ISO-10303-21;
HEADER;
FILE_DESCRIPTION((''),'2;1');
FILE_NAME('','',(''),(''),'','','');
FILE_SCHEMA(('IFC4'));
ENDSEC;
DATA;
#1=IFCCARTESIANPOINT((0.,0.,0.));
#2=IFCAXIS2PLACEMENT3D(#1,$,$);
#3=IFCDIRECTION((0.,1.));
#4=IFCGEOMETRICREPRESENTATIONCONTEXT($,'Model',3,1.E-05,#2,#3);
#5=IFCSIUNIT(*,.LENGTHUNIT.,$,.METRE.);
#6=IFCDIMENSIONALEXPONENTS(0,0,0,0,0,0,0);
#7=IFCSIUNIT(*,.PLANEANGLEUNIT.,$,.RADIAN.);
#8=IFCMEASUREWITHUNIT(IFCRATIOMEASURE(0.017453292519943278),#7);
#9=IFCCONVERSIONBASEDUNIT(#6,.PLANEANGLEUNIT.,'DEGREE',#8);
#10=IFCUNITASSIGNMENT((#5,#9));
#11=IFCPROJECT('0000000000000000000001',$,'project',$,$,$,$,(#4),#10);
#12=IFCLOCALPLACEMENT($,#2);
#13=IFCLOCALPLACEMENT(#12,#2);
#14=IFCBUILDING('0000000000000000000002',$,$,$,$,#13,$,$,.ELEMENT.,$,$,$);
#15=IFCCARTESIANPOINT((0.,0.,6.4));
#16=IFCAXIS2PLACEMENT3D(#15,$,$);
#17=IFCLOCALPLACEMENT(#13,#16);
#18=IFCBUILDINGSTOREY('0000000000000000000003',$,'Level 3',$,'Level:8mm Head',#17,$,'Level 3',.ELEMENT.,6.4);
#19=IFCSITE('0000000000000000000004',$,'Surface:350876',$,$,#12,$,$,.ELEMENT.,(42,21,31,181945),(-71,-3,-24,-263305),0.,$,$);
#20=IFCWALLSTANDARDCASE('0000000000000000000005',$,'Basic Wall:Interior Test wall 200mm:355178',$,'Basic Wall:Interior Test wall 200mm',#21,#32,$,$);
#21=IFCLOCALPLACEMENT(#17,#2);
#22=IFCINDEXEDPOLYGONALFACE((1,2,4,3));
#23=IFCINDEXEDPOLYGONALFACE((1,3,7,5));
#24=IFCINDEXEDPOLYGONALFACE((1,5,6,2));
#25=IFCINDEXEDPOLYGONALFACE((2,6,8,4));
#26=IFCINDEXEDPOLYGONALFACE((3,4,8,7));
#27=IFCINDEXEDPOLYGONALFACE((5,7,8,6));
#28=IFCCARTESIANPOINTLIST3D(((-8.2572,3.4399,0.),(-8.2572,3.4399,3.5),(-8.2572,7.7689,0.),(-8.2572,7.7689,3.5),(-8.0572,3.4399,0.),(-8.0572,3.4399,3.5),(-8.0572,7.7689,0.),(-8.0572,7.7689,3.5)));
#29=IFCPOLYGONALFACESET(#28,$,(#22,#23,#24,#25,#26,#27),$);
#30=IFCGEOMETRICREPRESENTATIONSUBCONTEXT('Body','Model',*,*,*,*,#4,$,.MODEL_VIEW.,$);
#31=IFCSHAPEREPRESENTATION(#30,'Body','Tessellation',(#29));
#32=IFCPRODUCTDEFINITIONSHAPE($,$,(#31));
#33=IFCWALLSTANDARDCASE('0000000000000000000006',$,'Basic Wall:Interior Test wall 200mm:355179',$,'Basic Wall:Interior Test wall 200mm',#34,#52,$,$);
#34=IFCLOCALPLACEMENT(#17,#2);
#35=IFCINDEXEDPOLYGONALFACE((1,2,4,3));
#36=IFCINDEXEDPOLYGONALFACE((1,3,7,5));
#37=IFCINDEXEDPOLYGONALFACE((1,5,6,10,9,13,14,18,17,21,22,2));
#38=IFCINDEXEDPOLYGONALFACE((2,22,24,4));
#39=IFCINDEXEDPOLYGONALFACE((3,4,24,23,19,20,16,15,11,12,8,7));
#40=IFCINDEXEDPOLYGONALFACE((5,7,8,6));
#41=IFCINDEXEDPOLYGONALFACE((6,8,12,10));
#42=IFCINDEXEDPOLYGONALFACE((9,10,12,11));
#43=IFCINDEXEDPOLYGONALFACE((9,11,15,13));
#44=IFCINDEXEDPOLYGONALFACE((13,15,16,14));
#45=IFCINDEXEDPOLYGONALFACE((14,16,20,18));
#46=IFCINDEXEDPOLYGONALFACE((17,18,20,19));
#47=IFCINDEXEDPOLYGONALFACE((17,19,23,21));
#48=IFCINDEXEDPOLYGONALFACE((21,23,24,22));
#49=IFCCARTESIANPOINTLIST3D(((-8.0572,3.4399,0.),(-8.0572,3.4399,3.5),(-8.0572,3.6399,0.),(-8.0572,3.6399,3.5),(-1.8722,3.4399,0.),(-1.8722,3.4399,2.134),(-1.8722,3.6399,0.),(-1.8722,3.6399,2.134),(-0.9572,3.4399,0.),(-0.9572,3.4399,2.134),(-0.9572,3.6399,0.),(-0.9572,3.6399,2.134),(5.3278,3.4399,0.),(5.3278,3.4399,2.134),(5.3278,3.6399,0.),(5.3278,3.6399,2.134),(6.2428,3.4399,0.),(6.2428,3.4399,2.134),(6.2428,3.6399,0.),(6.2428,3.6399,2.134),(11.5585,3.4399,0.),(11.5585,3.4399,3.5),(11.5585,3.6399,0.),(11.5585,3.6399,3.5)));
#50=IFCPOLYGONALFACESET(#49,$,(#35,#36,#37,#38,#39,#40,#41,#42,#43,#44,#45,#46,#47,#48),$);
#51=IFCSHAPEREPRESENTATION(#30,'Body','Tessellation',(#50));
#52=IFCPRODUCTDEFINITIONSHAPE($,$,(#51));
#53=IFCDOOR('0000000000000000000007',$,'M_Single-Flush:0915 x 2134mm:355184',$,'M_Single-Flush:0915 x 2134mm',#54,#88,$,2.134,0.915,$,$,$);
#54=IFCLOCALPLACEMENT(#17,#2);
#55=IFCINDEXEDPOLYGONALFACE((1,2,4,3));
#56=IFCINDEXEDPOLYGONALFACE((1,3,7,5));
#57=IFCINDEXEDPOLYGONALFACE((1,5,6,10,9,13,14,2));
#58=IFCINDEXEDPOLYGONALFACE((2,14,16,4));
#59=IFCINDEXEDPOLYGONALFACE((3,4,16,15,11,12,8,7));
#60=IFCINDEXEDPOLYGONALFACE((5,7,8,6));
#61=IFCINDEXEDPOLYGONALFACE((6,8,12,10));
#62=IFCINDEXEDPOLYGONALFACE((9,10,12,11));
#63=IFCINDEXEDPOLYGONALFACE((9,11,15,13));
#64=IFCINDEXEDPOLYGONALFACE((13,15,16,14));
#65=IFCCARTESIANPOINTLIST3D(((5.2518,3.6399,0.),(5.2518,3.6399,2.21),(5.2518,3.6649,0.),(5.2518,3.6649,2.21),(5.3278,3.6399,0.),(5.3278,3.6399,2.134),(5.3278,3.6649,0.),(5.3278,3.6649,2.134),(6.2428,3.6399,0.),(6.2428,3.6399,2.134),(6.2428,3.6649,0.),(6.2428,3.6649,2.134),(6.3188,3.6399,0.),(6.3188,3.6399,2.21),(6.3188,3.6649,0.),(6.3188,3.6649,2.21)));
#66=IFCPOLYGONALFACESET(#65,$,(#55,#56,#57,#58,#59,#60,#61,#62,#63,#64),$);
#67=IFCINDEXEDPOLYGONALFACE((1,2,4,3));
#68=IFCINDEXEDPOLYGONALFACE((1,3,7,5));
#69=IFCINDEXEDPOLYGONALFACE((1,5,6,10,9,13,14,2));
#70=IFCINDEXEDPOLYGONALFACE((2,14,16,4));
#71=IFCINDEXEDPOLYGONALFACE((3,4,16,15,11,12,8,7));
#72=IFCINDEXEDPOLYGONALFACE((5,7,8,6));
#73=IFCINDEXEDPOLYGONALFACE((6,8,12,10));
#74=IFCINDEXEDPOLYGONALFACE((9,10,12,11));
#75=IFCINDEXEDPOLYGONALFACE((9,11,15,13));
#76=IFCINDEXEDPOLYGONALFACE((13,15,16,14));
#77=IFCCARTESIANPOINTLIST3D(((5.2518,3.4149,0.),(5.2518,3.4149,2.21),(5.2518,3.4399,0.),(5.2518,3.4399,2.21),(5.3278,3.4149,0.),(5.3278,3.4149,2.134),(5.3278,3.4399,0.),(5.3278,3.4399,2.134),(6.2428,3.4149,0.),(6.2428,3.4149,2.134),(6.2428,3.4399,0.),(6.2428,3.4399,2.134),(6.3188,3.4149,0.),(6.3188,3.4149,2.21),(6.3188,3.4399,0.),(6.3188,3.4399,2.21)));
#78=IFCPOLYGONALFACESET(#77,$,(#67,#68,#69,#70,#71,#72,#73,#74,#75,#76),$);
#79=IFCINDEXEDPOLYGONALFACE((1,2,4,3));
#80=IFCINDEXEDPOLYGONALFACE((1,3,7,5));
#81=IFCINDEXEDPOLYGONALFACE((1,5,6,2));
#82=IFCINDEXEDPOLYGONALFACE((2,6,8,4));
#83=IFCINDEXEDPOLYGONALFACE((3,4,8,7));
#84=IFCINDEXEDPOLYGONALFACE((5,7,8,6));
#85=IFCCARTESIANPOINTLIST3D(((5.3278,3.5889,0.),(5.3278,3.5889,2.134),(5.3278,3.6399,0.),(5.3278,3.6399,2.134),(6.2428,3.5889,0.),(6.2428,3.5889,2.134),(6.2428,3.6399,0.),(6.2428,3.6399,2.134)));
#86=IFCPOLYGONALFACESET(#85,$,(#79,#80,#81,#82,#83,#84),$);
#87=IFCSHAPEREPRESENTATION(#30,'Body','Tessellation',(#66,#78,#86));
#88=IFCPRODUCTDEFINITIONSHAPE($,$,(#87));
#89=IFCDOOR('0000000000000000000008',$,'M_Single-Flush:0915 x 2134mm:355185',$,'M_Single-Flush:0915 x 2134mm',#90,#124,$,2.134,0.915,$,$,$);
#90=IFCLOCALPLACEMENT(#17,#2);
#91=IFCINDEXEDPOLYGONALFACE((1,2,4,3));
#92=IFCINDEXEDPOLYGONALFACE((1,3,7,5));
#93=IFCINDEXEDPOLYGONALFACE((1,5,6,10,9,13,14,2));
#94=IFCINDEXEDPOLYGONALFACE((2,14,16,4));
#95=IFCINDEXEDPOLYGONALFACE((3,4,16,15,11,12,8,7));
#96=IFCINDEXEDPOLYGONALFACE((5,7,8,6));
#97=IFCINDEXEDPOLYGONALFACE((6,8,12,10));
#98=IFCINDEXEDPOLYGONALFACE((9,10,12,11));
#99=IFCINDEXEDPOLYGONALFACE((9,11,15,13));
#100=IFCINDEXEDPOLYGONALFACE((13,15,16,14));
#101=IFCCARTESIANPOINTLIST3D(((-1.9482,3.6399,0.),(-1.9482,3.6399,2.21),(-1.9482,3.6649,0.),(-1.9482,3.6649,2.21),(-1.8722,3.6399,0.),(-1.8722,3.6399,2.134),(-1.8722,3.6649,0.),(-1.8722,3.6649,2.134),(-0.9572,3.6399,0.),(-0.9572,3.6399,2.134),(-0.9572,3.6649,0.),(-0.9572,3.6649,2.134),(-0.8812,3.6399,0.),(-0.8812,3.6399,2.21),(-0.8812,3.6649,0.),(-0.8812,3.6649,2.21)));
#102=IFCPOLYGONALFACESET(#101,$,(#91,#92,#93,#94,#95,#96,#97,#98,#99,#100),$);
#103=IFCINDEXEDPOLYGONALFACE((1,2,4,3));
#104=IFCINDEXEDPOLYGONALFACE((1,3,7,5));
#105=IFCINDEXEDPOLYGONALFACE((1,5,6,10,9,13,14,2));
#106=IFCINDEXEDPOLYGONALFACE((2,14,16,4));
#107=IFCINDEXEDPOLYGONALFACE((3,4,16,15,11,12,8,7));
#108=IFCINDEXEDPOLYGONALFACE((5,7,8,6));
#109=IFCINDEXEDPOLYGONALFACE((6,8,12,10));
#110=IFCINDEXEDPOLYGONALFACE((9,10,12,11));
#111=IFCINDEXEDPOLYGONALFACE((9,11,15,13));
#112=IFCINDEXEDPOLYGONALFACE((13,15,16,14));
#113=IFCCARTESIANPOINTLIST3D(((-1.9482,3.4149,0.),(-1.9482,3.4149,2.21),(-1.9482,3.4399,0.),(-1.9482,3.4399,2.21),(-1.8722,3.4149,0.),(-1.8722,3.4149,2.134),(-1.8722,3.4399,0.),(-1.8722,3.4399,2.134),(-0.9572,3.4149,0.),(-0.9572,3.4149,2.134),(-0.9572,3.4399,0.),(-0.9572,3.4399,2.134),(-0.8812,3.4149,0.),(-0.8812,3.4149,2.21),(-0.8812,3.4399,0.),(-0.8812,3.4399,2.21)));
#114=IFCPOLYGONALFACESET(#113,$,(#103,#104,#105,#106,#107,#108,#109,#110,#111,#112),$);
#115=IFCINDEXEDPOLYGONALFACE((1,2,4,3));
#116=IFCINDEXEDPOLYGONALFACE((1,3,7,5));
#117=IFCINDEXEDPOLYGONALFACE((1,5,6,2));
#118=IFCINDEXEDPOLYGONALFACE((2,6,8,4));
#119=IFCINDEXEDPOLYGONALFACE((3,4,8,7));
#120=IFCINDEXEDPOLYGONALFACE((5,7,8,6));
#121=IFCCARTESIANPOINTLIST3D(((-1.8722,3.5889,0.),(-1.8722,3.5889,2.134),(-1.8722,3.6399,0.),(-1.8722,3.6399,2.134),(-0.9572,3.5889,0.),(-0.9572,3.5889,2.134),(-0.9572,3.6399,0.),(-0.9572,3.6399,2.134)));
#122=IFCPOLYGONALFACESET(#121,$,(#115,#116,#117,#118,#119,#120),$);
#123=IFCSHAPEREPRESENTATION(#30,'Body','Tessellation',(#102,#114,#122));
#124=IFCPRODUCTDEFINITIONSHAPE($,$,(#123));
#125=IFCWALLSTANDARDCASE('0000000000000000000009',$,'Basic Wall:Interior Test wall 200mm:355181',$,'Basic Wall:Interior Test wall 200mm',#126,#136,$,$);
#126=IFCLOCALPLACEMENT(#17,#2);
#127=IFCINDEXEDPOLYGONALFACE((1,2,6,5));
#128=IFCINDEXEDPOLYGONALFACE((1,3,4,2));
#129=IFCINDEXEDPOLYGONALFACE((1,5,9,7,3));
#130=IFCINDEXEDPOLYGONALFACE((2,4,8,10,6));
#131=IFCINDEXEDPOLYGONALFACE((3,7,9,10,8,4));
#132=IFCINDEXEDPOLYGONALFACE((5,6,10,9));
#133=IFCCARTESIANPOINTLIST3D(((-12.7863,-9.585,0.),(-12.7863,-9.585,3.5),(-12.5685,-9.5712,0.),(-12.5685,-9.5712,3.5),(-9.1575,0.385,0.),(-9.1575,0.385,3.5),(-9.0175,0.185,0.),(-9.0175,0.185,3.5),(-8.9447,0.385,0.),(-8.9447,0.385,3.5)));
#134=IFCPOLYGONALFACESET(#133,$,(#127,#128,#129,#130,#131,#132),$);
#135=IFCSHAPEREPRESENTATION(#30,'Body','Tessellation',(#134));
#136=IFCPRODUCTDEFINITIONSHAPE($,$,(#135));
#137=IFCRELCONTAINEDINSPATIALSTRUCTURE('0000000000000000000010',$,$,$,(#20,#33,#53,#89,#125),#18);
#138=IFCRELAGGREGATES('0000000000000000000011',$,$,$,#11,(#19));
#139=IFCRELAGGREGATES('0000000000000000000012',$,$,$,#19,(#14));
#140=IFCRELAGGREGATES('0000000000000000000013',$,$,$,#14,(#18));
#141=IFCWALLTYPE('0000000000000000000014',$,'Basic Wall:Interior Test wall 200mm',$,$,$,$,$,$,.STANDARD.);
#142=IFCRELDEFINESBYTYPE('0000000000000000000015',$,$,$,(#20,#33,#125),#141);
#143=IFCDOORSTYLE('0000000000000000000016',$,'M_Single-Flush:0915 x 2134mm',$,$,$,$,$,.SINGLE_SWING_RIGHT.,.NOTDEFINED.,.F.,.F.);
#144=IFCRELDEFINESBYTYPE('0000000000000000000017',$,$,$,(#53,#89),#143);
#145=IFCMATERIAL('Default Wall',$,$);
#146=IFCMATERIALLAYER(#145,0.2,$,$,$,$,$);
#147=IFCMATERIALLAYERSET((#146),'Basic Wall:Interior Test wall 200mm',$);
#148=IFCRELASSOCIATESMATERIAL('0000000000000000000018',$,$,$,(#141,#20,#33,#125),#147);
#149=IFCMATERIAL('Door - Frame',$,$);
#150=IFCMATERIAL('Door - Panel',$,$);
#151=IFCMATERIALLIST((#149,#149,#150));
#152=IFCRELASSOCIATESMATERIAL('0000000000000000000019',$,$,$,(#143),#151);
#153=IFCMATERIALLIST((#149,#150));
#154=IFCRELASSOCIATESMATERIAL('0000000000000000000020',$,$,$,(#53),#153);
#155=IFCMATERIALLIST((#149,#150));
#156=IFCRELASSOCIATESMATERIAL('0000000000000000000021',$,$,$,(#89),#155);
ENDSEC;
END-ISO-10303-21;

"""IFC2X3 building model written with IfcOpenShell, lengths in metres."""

from ifc_helpers import new_model, entity, si_unit, converted_unit, direction, frame, frame_2d, origin, place, context, subcontext, project, spatial, polyline, rectangle, outline, extrude, source, transform, mapped, material, material_list, layer, layer_set, layer_usage, type_object, type_shapes, element, fill, save


model = new_model("IFC2X3")

# Units and contexts
model_context = context("Model", 3, precision=1e-05, world=origin(), true_north=direction((0.0, 1.0)))
body_context = subcontext(model_context, "Body", "Model", "MODEL_VIEW")
ifc_project = project(units=[si_unit("LENGTHUNIT", "METRE"), converted_unit("PLANEANGLEUNIT", "DEGREE", entity("IfcRatioMeasure", 0.017453292519943278), si_unit("PLANEANGLEUNIT", "RADIAN"), dimensions=[0, 0, 0, 0, 0, 0, 0])], contexts=[model_context])

# Site, building, storey
site_placement = place(None, origin())
site = spatial("IfcSite", under=ifc_project, at=site_placement, Name="Surface:350876", CompositionType="ELEMENT", RefLatitude=(42, 21, 31, 181945), RefLongitude=(-71, -3, -24, -263305), RefElevation=0.0)
building_placement = place(site_placement, origin())
building = spatial("IfcBuilding", under=site, at=building_placement, CompositionType="ELEMENT")
storey_placement = place(building_placement, frame((0.0, 0.0, 6.4)))
storey = spatial("IfcBuildingStorey", under=building, at=storey_placement, Name="Level 3", ObjectType="Level:8mm Head", LongName="Level 3", CompositionType="ELEMENT", Elevation=6.4)

# Shared definitions
ifc_material_1 = material(Name="Default Wall")

# Wall
ifc_layer_1 = layer(ifc_material_1, 0.2)
ifc_layer_set_1 = layer_set([ifc_layer_1], Name="Basic Wall:Interior Test wall 200mm")
ifc_layer_usage_1 = layer_usage(ifc_layer_set_1, "AXIS2", "NEGATIVE", 0.1)
wall_type_1 = type_object("IfcWallType", Name="Basic Wall:Interior Test wall 200mm", PredefinedType="STANDARD", material=ifc_layer_set_1)
wall_1_placement = place(storey_placement, frame((-8.1572, 7.7689, 0.0), z_axis=(0.0, 0.0, 1.0), x_axis=(0.0, -1.0, 0.0)))
element("IfcWallStandardCase", 1, at=wall_1_placement, inside=storey, type_object=wall_type_1, material=ifc_layer_usage_1, Name="Basic Wall:Interior Test wall 200mm:355178", ObjectType="Basic Wall:Interior Test wall 200mm", context=body_context, shape_type="SweptSolid", body=[
    extrude(rectangle(XDim=4.3289, YDim=0.2, at=frame_2d((2.1645, 0.0), x_axis=(-1.0, 0.0))), origin(), (0.0, 0.0, 1.0), 3.5),
])

# Wall, openings, doors
ifc_layer_usage_2 = layer_usage(ifc_layer_set_1, "AXIS2", "NEGATIVE", 0.1)
wall_2_placement = place(storey_placement, frame((-8.0572, 3.5399, 0.0)))
wall_2 = element("IfcWallStandardCase", 2, at=wall_2_placement, inside=storey, type_object=wall_type_1, material=ifc_layer_usage_2, Name="Basic Wall:Interior Test wall 200mm:355179", ObjectType="Basic Wall:Interior Test wall 200mm", context=body_context, shape_type="SweptSolid", body=[
    extrude(rectangle(XDim=19.6158, YDim=0.2, at=frame_2d((9.8079, 0.0), x_axis=(-1.0, 0.0))), origin(), (0.0, 0.0, 1.0), 3.5),
])
opening_1_placement = place(wall_2_placement, frame((13.385, -0.1, 0.0)))
opening_1 = element("IfcOpeningElement", 3, at=opening_1_placement, cuts=wall_2, ObjectType="Opening", context=body_context, shape_type="SweptSolid", body=[
    extrude(rectangle(XDim=0.915, YDim=2.134, at=frame_2d((1.067, 0.4575), x_axis=(0.0, 1.0))), frame((0.0, 0.0, 0.0), z_axis=(0.0, 1.0, 0.0), x_axis=(0.0, 0.0, 1.0)), (0.0, 0.0, 1.0), 0.2),
])
opening_2_placement = place(wall_2_placement, frame((6.185, -0.1, 0.0)))
opening_2 = element("IfcOpeningElement", 4, at=opening_2_placement, cuts=wall_2, ObjectType="Opening", context=body_context, shape_type="SweptSolid", body=[
    extrude(rectangle(XDim=0.915, YDim=2.134, at=frame_2d((1.067, 0.4575), x_axis=(0.0, 1.0))), frame((0.0, 0.0, 0.0), z_axis=(0.0, 1.0, 0.0), x_axis=(0.0, 0.0, 1.0)), (0.0, 0.0, 1.0), 0.2),
])
ifc_material_2 = material(Name="Door - Frame")
ifc_material_3 = material(Name="Door - Panel")
ifc_material_list_1 = material_list([ifc_material_2, ifc_material_3])
ifc_material_list_2 = material_list([ifc_material_2, ifc_material_2, ifc_material_3])
door_style_1 = type_object("IfcDoorStyle", Name="M_Single-Flush:0915 x 2134mm", ConstructionType="NOTDEFINED", OperationType="SINGLE_SWING_RIGHT", ParameterTakesPrecedence=False, Sizeable=False, material=ifc_material_list_2)
shared_shape_1 = source(origin(), body_context, "Body", "SweptSolid", [
    extrude(outline(polyline([(-0.5335, -1.124), (0.5335, -1.124), (0.5335, 1.086), (0.4575, 1.086), (0.4575, -1.048), (-0.4575, -1.048), (-0.4575, 1.086), (-0.5335, 1.086), (-0.5335, -1.124)])), frame((0.4575, 0.2, 1.086), z_axis=(0.0, 1.0, 0.0), x_axis=(1.0, 0.0, 0.0)), (0.0, 0.0, 1.0), 0.025),
    extrude(outline(polyline([(-1.124, -0.5335), (1.086, -0.5335), (1.086, -0.4575), (-1.048, -0.4575), (-1.048, 0.4575), (1.086, 0.4575), (1.086, 0.5335), (-1.124, 0.5335), (-1.124, -0.5335)])), frame((0.4575, -0.025, 1.086), z_axis=(0.0, 1.0, 0.0), x_axis=(0.0, 0.0, -1.0)), (0.0, 0.0, 1.0), 0.025),
    extrude(rectangle(XDim=0.051, YDim=0.915, at=frame_2d((0.0, 0.0), x_axis=(1.0, 0.0))), frame((0.4575, 0.1745, 0.0), z_axis=(0.0, 0.0, 1.0), x_axis=(0.0, 1.0, 0.0)), (0.0, 0.0, 1.0), 2.134),
])
type_shapes(door_style_1, [shared_shape_1])
door_1_placement = place(opening_1_placement, origin())
door_1 = element("IfcDoor", 5, at=door_1_placement, inside=storey, type_object=door_style_1, material=ifc_material_list_1, Name="M_Single-Flush:0915 x 2134mm:355184", ObjectType="M_Single-Flush:0915 x 2134mm", OverallHeight=2.134, OverallWidth=0.915, context=body_context, shape_type="MappedRepresentation", body=[
    mapped(shared_shape_1, transform((0.0, 0.0, 0.0), scale=1.0)),
])
fill(opening_1, door_1)
ifc_material_list_3 = material_list([ifc_material_2, ifc_material_3])
door_2_placement = place(opening_2_placement, origin())
door_2 = element("IfcDoor", 6, at=door_2_placement, inside=storey, type_object=door_style_1, material=ifc_material_list_3, Name="M_Single-Flush:0915 x 2134mm:355185", ObjectType="M_Single-Flush:0915 x 2134mm", OverallHeight=2.134, OverallWidth=0.915, context=body_context, shape_type="MappedRepresentation", body=[
    mapped(shared_shape_1, transform((0.0, 0.0, 0.0), scale=1.0)),
])
fill(opening_2, door_2)

# Wall
ifc_layer_usage_3 = layer_usage(ifc_layer_set_1, "AXIS2", "NEGATIVE", 0.1)
wall_3_placement = place(storey_placement, frame((-12.6924, -9.6192, 0.0), z_axis=(0.0, 0.0, 1.0), x_axis=(0.34202, 0.939693, 0.0)))
element("IfcWallStandardCase", 7, at=wall_3_placement, inside=storey, type_object=wall_type_1, material=ifc_layer_usage_3, Name="Basic Wall:Interior Test wall 200mm:355181", ObjectType="Basic Wall:Interior Test wall 200mm", context=body_context, shape_type="SweptSolid", body=[
    extrude(outline(polyline([(10.6827, -0.1), (10.6099, 0.1), (0.0, 0.1), (0.0875, -0.1), (10.4698, -0.1), (10.6827, -0.1)])), origin(), (0.0, 0.0, 1.0), 3.5),
])

save(model, "model.ifc")
